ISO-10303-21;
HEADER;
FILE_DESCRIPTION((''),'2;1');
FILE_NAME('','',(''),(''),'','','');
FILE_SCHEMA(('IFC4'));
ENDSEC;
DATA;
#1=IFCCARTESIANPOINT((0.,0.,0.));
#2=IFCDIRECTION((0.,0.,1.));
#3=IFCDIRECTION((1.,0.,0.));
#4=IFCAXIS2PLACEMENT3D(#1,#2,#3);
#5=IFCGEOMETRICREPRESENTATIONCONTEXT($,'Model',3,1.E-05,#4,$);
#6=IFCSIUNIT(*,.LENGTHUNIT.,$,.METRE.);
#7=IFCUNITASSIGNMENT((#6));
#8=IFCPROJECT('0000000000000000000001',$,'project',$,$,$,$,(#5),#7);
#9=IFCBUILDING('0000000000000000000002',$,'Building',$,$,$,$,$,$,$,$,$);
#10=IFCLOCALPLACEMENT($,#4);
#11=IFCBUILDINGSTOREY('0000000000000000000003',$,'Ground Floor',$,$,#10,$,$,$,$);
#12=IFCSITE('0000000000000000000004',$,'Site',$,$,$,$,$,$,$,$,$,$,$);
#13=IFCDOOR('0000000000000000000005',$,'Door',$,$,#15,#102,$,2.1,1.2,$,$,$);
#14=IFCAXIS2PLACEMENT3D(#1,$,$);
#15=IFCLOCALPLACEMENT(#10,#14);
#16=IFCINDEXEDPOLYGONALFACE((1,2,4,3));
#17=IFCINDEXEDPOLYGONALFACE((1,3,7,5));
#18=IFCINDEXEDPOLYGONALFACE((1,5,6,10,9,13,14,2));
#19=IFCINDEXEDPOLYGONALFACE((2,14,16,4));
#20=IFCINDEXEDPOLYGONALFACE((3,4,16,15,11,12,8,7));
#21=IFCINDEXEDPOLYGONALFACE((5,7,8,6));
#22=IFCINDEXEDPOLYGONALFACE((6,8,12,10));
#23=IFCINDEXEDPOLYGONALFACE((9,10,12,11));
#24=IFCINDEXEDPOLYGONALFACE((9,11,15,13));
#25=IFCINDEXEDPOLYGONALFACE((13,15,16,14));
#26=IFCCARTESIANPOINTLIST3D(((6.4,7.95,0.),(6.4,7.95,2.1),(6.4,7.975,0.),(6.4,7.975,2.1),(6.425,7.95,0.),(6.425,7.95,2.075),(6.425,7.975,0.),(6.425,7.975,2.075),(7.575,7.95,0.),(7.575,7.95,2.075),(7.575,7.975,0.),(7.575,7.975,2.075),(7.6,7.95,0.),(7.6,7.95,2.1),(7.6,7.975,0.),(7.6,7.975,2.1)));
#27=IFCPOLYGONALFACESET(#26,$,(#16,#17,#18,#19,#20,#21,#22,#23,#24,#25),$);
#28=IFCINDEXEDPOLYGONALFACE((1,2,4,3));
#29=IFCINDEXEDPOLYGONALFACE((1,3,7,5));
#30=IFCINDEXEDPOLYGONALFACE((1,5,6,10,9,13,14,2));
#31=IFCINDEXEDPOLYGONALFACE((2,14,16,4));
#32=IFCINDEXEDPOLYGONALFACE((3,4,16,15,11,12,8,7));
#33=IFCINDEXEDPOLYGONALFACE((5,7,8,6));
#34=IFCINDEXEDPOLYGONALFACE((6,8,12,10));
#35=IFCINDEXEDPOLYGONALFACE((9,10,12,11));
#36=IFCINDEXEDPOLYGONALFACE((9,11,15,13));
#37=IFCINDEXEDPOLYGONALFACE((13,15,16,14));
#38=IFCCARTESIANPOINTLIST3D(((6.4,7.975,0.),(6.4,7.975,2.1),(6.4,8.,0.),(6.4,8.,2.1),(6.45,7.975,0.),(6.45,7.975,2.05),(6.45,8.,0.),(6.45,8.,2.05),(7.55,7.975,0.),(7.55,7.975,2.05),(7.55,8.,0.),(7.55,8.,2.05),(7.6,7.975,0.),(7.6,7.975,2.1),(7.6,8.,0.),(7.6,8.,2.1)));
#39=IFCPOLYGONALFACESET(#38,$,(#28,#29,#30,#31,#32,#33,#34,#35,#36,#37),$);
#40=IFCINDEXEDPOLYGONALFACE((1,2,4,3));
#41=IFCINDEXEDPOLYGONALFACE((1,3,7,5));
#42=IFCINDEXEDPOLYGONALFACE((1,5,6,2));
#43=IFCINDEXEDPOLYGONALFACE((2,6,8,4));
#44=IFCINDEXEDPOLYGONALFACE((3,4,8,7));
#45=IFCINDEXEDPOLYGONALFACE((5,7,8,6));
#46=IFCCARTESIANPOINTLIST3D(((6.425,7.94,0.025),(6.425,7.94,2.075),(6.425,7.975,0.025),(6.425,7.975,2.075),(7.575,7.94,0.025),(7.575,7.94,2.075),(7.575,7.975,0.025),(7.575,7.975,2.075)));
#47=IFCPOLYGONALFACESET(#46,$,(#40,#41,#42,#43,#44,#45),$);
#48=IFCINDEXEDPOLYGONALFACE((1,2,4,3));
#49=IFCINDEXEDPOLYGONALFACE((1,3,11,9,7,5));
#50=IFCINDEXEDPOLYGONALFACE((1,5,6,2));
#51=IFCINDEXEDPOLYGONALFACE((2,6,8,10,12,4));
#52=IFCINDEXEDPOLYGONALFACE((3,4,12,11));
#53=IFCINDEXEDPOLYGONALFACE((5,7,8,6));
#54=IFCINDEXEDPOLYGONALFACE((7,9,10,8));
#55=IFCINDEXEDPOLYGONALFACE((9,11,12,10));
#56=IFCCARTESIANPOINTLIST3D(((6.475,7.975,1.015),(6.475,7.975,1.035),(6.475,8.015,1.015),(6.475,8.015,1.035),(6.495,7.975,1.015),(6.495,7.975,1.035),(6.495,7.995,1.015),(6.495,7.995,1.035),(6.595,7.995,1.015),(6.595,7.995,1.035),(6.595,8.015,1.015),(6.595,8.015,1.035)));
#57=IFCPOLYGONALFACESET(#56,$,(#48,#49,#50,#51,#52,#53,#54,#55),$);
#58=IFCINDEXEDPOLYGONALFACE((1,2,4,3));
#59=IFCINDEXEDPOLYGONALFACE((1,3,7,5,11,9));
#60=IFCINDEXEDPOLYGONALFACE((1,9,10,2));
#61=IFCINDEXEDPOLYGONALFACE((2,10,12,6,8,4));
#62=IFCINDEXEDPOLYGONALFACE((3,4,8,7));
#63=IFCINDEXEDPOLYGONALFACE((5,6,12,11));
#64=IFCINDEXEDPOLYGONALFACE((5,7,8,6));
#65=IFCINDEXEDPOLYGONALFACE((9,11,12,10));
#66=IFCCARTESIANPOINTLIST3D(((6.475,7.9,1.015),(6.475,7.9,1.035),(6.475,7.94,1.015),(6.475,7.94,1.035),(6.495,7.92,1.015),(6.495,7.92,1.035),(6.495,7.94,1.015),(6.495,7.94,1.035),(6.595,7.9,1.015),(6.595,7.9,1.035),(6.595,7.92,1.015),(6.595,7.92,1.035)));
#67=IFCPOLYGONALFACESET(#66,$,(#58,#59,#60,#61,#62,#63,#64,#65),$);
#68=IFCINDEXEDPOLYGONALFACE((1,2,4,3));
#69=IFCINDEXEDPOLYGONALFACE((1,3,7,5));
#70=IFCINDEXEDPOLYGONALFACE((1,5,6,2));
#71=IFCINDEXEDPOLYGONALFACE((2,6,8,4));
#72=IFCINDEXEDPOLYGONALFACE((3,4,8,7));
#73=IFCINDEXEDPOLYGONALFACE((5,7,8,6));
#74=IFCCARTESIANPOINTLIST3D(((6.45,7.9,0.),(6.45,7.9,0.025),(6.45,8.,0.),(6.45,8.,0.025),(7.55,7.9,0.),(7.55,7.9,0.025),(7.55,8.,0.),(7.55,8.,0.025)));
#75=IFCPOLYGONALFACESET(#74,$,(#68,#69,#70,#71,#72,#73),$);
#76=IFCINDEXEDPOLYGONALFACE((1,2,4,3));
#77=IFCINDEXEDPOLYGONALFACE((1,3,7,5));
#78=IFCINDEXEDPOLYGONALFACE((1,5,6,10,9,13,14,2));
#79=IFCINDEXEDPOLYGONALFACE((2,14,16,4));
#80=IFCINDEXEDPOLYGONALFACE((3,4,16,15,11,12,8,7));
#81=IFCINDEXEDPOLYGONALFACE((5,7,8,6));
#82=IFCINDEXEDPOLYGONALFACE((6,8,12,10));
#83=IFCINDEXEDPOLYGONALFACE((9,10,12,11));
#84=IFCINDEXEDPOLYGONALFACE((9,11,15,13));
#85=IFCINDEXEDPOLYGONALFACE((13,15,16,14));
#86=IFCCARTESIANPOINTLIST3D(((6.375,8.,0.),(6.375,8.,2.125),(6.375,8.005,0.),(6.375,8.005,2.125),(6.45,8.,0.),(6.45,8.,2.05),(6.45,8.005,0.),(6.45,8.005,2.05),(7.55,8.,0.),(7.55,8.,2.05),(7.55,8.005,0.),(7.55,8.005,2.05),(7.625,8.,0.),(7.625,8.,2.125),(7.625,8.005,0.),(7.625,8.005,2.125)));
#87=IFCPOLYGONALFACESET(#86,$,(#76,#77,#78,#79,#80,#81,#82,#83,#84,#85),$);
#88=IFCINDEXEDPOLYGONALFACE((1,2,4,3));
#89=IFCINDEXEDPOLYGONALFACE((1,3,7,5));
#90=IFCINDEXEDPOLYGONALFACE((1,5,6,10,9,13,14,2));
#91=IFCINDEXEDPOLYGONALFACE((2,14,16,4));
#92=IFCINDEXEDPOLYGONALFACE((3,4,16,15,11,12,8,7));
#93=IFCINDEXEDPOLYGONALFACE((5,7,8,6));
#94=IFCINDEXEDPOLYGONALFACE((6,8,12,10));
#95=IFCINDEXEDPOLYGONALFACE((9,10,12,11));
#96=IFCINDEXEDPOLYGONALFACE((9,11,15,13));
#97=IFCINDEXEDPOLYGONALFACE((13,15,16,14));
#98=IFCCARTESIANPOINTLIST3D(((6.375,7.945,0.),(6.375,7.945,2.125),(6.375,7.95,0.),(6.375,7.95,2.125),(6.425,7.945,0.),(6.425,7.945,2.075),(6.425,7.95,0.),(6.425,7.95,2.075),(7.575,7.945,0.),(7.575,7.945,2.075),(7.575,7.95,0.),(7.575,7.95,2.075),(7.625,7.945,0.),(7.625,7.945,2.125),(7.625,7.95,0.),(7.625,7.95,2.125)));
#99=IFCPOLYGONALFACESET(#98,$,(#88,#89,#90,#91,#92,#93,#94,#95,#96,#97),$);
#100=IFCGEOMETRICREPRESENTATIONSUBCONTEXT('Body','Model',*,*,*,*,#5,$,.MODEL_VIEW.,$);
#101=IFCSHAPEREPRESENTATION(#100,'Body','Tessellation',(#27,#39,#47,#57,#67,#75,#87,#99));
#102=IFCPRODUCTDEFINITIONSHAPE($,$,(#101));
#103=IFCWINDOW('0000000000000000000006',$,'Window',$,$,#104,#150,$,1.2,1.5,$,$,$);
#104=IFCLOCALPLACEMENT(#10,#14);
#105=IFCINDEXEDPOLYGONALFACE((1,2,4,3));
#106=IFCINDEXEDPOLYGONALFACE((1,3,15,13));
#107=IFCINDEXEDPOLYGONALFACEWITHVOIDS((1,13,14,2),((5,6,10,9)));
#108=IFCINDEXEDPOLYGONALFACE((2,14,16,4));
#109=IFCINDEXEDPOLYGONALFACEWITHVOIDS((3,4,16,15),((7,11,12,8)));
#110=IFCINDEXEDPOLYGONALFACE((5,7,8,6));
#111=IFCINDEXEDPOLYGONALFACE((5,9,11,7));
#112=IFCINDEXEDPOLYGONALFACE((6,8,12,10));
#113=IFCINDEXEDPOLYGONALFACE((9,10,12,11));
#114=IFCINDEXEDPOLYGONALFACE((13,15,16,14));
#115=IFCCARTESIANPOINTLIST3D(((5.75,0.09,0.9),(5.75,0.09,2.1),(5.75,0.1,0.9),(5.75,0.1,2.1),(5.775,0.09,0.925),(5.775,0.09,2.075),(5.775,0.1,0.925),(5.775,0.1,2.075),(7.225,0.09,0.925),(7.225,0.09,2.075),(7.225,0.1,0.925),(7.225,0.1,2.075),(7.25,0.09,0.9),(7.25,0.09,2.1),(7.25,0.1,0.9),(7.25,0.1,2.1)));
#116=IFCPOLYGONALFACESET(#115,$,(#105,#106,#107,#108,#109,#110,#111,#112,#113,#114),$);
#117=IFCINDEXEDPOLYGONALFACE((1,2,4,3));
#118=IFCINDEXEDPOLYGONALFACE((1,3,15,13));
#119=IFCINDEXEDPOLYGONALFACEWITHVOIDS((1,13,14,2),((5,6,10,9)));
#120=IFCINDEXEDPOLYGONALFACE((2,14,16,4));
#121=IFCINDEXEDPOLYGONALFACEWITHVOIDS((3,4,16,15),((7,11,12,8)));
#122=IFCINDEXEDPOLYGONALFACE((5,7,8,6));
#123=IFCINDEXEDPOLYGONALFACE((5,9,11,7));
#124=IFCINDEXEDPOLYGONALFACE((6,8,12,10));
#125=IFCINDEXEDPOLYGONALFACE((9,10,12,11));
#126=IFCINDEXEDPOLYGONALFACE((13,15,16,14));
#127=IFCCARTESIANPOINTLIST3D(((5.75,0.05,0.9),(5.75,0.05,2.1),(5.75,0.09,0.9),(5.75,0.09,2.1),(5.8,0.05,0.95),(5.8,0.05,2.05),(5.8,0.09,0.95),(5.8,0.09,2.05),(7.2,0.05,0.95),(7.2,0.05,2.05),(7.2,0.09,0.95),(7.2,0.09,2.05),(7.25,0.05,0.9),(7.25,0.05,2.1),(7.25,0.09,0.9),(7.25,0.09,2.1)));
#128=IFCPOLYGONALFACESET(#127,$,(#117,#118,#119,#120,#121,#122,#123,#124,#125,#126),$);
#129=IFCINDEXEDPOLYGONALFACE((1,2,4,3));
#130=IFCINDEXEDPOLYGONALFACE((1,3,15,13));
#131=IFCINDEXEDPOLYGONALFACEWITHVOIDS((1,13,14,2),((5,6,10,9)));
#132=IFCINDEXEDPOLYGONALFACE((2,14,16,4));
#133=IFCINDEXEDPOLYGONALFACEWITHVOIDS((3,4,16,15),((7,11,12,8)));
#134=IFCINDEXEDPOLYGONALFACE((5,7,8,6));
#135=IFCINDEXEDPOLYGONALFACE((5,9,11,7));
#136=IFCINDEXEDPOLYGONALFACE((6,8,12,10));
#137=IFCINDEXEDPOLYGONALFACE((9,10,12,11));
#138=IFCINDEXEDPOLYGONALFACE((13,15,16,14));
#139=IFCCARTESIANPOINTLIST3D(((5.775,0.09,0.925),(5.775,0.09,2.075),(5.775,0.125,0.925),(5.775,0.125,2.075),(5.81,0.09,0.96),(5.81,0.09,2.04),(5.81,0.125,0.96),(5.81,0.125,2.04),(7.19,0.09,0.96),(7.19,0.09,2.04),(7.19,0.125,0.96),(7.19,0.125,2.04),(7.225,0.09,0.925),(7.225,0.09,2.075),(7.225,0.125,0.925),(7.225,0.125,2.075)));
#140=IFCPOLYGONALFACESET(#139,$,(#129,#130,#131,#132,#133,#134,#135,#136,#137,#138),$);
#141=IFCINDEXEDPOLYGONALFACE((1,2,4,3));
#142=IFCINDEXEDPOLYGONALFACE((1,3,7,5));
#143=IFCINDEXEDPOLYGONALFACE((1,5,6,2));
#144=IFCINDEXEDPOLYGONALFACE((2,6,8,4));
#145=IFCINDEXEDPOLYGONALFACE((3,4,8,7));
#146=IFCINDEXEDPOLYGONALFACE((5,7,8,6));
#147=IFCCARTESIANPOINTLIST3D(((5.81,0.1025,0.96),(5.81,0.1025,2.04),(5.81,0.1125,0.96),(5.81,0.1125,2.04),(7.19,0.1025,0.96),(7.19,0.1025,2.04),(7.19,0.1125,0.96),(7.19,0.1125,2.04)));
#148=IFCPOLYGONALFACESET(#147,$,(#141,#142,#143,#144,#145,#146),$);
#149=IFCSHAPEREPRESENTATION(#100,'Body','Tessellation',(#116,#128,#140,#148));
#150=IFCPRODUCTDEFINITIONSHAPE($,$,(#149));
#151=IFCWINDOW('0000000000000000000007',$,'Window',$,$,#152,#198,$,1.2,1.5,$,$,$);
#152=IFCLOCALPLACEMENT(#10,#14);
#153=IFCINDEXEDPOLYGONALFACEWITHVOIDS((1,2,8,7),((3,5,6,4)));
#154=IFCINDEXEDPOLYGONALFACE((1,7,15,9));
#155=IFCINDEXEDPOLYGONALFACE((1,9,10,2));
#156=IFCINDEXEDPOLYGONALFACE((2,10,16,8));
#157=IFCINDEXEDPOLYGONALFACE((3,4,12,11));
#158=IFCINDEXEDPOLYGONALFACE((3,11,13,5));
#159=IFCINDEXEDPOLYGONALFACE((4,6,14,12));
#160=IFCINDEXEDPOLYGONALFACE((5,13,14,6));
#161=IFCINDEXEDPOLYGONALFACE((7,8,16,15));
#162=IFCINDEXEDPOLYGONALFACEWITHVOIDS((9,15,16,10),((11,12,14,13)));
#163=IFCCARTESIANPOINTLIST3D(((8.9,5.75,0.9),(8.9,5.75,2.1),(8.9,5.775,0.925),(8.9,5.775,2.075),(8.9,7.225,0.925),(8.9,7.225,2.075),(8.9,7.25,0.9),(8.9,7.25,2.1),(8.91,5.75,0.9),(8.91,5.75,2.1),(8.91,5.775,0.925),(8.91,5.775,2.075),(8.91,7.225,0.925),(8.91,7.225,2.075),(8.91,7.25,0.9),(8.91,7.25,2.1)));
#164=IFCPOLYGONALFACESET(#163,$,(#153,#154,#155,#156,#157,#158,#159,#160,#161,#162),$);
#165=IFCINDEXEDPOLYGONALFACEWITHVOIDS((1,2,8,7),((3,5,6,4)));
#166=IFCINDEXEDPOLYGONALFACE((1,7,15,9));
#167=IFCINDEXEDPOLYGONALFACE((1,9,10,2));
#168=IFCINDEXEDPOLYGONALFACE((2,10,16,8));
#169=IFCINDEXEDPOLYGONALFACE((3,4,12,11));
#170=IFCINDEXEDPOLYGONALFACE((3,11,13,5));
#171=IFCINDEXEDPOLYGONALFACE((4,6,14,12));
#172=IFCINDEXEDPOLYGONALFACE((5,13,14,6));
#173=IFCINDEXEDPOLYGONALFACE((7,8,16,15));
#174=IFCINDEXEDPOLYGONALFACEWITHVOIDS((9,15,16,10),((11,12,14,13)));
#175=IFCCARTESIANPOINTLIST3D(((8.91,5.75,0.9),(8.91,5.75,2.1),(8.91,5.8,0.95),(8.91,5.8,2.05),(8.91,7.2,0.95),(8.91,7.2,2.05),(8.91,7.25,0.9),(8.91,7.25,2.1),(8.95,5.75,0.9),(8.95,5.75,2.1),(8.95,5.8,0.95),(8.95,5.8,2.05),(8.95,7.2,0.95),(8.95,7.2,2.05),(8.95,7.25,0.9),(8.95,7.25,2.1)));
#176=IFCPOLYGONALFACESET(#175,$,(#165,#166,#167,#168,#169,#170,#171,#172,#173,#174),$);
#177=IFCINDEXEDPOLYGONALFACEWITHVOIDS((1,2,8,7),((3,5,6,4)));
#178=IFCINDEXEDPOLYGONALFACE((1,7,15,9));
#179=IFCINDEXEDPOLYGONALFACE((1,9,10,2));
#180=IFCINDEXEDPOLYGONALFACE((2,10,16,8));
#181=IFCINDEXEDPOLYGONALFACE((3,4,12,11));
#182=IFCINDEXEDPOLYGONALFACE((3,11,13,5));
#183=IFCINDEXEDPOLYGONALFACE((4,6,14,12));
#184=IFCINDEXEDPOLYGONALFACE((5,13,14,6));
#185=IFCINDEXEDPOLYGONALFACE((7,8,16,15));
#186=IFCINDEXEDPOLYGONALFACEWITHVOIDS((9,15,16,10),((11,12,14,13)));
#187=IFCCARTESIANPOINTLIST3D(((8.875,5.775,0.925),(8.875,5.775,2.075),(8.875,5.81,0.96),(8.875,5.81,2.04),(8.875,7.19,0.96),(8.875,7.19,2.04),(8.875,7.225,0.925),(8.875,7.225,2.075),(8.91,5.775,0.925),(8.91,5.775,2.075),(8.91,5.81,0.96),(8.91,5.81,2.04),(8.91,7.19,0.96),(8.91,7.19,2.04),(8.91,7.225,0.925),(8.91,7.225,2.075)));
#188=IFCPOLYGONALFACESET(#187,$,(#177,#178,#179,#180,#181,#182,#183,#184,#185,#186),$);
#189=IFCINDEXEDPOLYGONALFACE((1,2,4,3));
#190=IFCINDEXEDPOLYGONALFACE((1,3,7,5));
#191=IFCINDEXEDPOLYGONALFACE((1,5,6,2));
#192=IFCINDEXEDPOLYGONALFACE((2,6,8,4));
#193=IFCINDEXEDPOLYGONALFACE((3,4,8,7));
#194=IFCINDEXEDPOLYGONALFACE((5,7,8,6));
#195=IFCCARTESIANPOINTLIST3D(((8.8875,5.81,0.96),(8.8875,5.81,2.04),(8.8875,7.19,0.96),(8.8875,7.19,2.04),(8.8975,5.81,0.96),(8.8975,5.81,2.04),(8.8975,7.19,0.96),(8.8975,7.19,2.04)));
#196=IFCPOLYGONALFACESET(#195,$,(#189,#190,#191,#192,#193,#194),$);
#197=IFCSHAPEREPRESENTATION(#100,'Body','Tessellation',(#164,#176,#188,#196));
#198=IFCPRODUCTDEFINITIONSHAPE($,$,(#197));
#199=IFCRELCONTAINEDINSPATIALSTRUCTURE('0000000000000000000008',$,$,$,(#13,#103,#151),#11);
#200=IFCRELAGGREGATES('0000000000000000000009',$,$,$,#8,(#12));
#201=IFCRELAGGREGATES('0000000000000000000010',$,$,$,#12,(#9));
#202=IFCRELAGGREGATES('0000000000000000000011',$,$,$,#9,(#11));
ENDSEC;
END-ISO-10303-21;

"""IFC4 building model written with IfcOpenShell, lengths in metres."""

from ifc_helpers import new_model, si_unit, frame, origin_with_axes, place, context, subcontext, project, spatial, line, indexed_curve, outline, extrude, element, save


model = new_model("IFC4")

# Units and contexts
model_context = context("Model", 3, precision=1e-05, world=origin_with_axes())
body_context = subcontext(model_context, "Body", "Model", "MODEL_VIEW")
ifc_project = project(units=[si_unit("LENGTHUNIT", "METRE")], contexts=[model_context])

# Site, building, storey
site = spatial("IfcSite", under=ifc_project, Name="Site")
building = spatial("IfcBuilding", under=site, Name="Building")
storey_placement = place(None, origin_with_axes())
storey = spatial("IfcBuildingStorey", under=building, at=storey_placement, Name="Ground Floor")

# Door
door_1_placement = place(storey_placement, frame((7.6, 8.0, 0.0), z_axis=(0.0, 0.0, 1.0), x_axis=(-1.0, 0.0, 0.0)))
element("IfcDoor", 1, at=door_1_placement, inside=storey, Name="Door", OverallHeight=2.1, OverallWidth=1.2, context=body_context, shape_type="SweptSolid", body=[
    extrude(outline(indexed_curve([(0.0, 0.0), (0.0, 2.1), (1.2, 2.1), (1.2, 0.0), (1.175, 0.0), (1.175, 2.075), (0.025, 2.075), (0.025, 0.0)], segments=[line(1, 2, 3, 4, 5, 6, 7, 8, 1)])), frame((0.0, 0.025, 0.0), z_axis=(0.0, -1.0, 0.0), x_axis=(1.0, 0.0, 0.0)), (0.0, 0.0, -1.0), 0.025),
    extrude(outline(indexed_curve([(0.0, 0.0), (0.0, 2.1), (1.2, 2.1), (1.2, 0.0), (1.15, 0.0), (1.15, 2.05), (0.05, 2.05), (0.05, 0.0)], segments=[line(1, 2, 3, 4, 5, 6, 7, 8, 1)])), frame((0.0, 0.0, 0.0), z_axis=(0.0, -1.0, 0.0), x_axis=(1.0, 0.0, 0.0)), (0.0, 0.0, -1.0), 0.025),
    extrude(outline(indexed_curve([(0.0, 0.0), (1.15, 0.0), (1.15, 0.035), (0.0, 0.035)], segments=[line(1, 2, 3, 4, 1)])), frame((0.025, 0.025, 0.025), z_axis=(0.0, 0.0, 1.0), x_axis=(1.0, 0.0, 0.0)), (0.0, 0.0, 1.0), 2.05),
    extrude(outline(indexed_curve([(0.0, 0.0), (0.0, -0.04), (-0.12, -0.04), (-0.12, -0.02), (-0.02, -0.02), (-0.02, 0.0)], segments=[line(1, 2, 3, 4, 5, 6, 1)])), frame((1.125, 0.025, 1.015), z_axis=(0.0, 0.0, 1.0), x_axis=(1.0, 0.0, 0.0)), (0.0, 0.0, 1.0), 0.02),
    extrude(outline(indexed_curve([(0.0, 0.0), (0.0, 0.04), (-0.12, 0.04), (-0.12, 0.02), (-0.02, 0.02), (-0.02, 0.0)], segments=[line(1, 2, 3, 4, 5, 6, 1)])), frame((1.125, 0.06, 1.015), z_axis=(0.0, 0.0, 1.0), x_axis=(1.0, 0.0, 0.0)), (0.0, 0.0, 1.0), 0.02),
    extrude(outline(indexed_curve([(0.0, 0.0), (1.1, 0.0), (1.1, 0.1), (0.0, 0.1)], segments=[line(1, 2, 3, 4, 1)])), frame((0.05, 0.0, 0.0), z_axis=(0.0, 0.0, 1.0), x_axis=(1.0, 0.0, 0.0)), (0.0, 0.0, 1.0), 0.025),
    extrude(outline(indexed_curve([(0.0, 0.0), (0.0, 2.125), (1.25, 2.125), (1.25, 0.0), (1.175, 0.0), (1.175, 2.05), (0.075, 2.05), (0.075, 0.0)], segments=[line(1, 2, 3, 4, 5, 6, 7, 8, 1)])), frame((-0.025, -0.005, 0.0), z_axis=(0.0, -1.0, 0.0), x_axis=(1.0, 0.0, 0.0)), (0.0, 0.0, -1.0), 0.005),
    extrude(outline(indexed_curve([(0.0, 0.0), (0.0, 2.125), (1.25, 2.125), (1.25, 0.0), (1.2, 0.0), (1.2, 2.075), (0.05, 2.075), (0.05, 0.0)], segments=[line(1, 2, 3, 4, 5, 6, 7, 8, 1)])), frame((-0.025, 0.05, 0.0), z_axis=(0.0, -1.0, 0.0), x_axis=(1.0, 0.0, 0.0)), (0.0, 0.0, -1.0), 0.005),
])

# Windows
for number, where, z_axis, x_axis, name in (
    (2, (5.75, 0.0, 0.9), (0.0, 0.0, 1.0), (1.0, 0.0, 0.0), "Window"),
    (3, (9.0, 5.75, 0.9), (0.0, 0.0, 1.0), (0.0, 1.0, 0.0), "Window"),
):
    element("IfcWindow", number, at=place(storey_placement, frame(where, z_axis=z_axis, x_axis=x_axis)), inside=storey, Name=name, OverallHeight=1.2, OverallWidth=1.5, context=body_context, shape_type="SweptSolid", body=[
        extrude(outline(indexed_curve([(0.0, 0.0), (1.5, 0.0), (1.5, 1.2), (0.0, 1.2)], segments=[line(1, 2, 3, 4, 1)]), holes=[indexed_curve([(0.025, 0.025), (1.475, 0.025), (1.475, 1.175), (0.025, 1.175)], segments=[line(1, 2, 3, 4, 1)])]), frame((0.0, 0.09, 0.0), z_axis=(0.0, -1.0, 0.0), x_axis=(1.0, 0.0, 0.0)), (0.0, 0.0, -1.0), 0.01),
        extrude(outline(indexed_curve([(0.0, 0.0), (1.5, 0.0), (1.5, 1.2), (0.0, 1.2)], segments=[line(1, 2, 3, 4, 1)]), holes=[indexed_curve([(0.05, 0.05), (1.45, 0.05), (1.45, 1.15), (0.05, 1.15)], segments=[line(1, 2, 3, 4, 1)])]), frame((0.0, 0.05, 0.0), z_axis=(0.0, -1.0, 0.0), x_axis=(1.0, 0.0, 0.0)), (0.0, 0.0, -1.0), 0.04),
        extrude(outline(indexed_curve([(0.0, 0.0), (1.45, 0.0), (1.45, 1.15), (0.0, 1.15)], segments=[line(1, 2, 3, 4, 1)]), holes=[indexed_curve([(0.035, 0.035), (1.415, 0.035), (1.415, 1.115), (0.035, 1.115)], segments=[line(1, 2, 3, 4, 1)])]), frame((0.025, 0.09, 0.025), z_axis=(0.0, -1.0, 0.0), x_axis=(1.0, 0.0, 0.0)), (0.0, 0.0, -1.0), 0.035),
        extrude(outline(indexed_curve([(0.035, 0.035), (1.415, 0.035), (1.415, 1.115), (0.035, 1.115)], segments=[line(1, 2, 3, 4, 1)])), frame((0.025, 0.1025, 0.025), z_axis=(0.0, -1.0, 0.0), x_axis=(1.0, 0.0, 0.0)), (0.0, 0.0, -1.0), 0.01),
    ])

save(model, "model.ifc")
